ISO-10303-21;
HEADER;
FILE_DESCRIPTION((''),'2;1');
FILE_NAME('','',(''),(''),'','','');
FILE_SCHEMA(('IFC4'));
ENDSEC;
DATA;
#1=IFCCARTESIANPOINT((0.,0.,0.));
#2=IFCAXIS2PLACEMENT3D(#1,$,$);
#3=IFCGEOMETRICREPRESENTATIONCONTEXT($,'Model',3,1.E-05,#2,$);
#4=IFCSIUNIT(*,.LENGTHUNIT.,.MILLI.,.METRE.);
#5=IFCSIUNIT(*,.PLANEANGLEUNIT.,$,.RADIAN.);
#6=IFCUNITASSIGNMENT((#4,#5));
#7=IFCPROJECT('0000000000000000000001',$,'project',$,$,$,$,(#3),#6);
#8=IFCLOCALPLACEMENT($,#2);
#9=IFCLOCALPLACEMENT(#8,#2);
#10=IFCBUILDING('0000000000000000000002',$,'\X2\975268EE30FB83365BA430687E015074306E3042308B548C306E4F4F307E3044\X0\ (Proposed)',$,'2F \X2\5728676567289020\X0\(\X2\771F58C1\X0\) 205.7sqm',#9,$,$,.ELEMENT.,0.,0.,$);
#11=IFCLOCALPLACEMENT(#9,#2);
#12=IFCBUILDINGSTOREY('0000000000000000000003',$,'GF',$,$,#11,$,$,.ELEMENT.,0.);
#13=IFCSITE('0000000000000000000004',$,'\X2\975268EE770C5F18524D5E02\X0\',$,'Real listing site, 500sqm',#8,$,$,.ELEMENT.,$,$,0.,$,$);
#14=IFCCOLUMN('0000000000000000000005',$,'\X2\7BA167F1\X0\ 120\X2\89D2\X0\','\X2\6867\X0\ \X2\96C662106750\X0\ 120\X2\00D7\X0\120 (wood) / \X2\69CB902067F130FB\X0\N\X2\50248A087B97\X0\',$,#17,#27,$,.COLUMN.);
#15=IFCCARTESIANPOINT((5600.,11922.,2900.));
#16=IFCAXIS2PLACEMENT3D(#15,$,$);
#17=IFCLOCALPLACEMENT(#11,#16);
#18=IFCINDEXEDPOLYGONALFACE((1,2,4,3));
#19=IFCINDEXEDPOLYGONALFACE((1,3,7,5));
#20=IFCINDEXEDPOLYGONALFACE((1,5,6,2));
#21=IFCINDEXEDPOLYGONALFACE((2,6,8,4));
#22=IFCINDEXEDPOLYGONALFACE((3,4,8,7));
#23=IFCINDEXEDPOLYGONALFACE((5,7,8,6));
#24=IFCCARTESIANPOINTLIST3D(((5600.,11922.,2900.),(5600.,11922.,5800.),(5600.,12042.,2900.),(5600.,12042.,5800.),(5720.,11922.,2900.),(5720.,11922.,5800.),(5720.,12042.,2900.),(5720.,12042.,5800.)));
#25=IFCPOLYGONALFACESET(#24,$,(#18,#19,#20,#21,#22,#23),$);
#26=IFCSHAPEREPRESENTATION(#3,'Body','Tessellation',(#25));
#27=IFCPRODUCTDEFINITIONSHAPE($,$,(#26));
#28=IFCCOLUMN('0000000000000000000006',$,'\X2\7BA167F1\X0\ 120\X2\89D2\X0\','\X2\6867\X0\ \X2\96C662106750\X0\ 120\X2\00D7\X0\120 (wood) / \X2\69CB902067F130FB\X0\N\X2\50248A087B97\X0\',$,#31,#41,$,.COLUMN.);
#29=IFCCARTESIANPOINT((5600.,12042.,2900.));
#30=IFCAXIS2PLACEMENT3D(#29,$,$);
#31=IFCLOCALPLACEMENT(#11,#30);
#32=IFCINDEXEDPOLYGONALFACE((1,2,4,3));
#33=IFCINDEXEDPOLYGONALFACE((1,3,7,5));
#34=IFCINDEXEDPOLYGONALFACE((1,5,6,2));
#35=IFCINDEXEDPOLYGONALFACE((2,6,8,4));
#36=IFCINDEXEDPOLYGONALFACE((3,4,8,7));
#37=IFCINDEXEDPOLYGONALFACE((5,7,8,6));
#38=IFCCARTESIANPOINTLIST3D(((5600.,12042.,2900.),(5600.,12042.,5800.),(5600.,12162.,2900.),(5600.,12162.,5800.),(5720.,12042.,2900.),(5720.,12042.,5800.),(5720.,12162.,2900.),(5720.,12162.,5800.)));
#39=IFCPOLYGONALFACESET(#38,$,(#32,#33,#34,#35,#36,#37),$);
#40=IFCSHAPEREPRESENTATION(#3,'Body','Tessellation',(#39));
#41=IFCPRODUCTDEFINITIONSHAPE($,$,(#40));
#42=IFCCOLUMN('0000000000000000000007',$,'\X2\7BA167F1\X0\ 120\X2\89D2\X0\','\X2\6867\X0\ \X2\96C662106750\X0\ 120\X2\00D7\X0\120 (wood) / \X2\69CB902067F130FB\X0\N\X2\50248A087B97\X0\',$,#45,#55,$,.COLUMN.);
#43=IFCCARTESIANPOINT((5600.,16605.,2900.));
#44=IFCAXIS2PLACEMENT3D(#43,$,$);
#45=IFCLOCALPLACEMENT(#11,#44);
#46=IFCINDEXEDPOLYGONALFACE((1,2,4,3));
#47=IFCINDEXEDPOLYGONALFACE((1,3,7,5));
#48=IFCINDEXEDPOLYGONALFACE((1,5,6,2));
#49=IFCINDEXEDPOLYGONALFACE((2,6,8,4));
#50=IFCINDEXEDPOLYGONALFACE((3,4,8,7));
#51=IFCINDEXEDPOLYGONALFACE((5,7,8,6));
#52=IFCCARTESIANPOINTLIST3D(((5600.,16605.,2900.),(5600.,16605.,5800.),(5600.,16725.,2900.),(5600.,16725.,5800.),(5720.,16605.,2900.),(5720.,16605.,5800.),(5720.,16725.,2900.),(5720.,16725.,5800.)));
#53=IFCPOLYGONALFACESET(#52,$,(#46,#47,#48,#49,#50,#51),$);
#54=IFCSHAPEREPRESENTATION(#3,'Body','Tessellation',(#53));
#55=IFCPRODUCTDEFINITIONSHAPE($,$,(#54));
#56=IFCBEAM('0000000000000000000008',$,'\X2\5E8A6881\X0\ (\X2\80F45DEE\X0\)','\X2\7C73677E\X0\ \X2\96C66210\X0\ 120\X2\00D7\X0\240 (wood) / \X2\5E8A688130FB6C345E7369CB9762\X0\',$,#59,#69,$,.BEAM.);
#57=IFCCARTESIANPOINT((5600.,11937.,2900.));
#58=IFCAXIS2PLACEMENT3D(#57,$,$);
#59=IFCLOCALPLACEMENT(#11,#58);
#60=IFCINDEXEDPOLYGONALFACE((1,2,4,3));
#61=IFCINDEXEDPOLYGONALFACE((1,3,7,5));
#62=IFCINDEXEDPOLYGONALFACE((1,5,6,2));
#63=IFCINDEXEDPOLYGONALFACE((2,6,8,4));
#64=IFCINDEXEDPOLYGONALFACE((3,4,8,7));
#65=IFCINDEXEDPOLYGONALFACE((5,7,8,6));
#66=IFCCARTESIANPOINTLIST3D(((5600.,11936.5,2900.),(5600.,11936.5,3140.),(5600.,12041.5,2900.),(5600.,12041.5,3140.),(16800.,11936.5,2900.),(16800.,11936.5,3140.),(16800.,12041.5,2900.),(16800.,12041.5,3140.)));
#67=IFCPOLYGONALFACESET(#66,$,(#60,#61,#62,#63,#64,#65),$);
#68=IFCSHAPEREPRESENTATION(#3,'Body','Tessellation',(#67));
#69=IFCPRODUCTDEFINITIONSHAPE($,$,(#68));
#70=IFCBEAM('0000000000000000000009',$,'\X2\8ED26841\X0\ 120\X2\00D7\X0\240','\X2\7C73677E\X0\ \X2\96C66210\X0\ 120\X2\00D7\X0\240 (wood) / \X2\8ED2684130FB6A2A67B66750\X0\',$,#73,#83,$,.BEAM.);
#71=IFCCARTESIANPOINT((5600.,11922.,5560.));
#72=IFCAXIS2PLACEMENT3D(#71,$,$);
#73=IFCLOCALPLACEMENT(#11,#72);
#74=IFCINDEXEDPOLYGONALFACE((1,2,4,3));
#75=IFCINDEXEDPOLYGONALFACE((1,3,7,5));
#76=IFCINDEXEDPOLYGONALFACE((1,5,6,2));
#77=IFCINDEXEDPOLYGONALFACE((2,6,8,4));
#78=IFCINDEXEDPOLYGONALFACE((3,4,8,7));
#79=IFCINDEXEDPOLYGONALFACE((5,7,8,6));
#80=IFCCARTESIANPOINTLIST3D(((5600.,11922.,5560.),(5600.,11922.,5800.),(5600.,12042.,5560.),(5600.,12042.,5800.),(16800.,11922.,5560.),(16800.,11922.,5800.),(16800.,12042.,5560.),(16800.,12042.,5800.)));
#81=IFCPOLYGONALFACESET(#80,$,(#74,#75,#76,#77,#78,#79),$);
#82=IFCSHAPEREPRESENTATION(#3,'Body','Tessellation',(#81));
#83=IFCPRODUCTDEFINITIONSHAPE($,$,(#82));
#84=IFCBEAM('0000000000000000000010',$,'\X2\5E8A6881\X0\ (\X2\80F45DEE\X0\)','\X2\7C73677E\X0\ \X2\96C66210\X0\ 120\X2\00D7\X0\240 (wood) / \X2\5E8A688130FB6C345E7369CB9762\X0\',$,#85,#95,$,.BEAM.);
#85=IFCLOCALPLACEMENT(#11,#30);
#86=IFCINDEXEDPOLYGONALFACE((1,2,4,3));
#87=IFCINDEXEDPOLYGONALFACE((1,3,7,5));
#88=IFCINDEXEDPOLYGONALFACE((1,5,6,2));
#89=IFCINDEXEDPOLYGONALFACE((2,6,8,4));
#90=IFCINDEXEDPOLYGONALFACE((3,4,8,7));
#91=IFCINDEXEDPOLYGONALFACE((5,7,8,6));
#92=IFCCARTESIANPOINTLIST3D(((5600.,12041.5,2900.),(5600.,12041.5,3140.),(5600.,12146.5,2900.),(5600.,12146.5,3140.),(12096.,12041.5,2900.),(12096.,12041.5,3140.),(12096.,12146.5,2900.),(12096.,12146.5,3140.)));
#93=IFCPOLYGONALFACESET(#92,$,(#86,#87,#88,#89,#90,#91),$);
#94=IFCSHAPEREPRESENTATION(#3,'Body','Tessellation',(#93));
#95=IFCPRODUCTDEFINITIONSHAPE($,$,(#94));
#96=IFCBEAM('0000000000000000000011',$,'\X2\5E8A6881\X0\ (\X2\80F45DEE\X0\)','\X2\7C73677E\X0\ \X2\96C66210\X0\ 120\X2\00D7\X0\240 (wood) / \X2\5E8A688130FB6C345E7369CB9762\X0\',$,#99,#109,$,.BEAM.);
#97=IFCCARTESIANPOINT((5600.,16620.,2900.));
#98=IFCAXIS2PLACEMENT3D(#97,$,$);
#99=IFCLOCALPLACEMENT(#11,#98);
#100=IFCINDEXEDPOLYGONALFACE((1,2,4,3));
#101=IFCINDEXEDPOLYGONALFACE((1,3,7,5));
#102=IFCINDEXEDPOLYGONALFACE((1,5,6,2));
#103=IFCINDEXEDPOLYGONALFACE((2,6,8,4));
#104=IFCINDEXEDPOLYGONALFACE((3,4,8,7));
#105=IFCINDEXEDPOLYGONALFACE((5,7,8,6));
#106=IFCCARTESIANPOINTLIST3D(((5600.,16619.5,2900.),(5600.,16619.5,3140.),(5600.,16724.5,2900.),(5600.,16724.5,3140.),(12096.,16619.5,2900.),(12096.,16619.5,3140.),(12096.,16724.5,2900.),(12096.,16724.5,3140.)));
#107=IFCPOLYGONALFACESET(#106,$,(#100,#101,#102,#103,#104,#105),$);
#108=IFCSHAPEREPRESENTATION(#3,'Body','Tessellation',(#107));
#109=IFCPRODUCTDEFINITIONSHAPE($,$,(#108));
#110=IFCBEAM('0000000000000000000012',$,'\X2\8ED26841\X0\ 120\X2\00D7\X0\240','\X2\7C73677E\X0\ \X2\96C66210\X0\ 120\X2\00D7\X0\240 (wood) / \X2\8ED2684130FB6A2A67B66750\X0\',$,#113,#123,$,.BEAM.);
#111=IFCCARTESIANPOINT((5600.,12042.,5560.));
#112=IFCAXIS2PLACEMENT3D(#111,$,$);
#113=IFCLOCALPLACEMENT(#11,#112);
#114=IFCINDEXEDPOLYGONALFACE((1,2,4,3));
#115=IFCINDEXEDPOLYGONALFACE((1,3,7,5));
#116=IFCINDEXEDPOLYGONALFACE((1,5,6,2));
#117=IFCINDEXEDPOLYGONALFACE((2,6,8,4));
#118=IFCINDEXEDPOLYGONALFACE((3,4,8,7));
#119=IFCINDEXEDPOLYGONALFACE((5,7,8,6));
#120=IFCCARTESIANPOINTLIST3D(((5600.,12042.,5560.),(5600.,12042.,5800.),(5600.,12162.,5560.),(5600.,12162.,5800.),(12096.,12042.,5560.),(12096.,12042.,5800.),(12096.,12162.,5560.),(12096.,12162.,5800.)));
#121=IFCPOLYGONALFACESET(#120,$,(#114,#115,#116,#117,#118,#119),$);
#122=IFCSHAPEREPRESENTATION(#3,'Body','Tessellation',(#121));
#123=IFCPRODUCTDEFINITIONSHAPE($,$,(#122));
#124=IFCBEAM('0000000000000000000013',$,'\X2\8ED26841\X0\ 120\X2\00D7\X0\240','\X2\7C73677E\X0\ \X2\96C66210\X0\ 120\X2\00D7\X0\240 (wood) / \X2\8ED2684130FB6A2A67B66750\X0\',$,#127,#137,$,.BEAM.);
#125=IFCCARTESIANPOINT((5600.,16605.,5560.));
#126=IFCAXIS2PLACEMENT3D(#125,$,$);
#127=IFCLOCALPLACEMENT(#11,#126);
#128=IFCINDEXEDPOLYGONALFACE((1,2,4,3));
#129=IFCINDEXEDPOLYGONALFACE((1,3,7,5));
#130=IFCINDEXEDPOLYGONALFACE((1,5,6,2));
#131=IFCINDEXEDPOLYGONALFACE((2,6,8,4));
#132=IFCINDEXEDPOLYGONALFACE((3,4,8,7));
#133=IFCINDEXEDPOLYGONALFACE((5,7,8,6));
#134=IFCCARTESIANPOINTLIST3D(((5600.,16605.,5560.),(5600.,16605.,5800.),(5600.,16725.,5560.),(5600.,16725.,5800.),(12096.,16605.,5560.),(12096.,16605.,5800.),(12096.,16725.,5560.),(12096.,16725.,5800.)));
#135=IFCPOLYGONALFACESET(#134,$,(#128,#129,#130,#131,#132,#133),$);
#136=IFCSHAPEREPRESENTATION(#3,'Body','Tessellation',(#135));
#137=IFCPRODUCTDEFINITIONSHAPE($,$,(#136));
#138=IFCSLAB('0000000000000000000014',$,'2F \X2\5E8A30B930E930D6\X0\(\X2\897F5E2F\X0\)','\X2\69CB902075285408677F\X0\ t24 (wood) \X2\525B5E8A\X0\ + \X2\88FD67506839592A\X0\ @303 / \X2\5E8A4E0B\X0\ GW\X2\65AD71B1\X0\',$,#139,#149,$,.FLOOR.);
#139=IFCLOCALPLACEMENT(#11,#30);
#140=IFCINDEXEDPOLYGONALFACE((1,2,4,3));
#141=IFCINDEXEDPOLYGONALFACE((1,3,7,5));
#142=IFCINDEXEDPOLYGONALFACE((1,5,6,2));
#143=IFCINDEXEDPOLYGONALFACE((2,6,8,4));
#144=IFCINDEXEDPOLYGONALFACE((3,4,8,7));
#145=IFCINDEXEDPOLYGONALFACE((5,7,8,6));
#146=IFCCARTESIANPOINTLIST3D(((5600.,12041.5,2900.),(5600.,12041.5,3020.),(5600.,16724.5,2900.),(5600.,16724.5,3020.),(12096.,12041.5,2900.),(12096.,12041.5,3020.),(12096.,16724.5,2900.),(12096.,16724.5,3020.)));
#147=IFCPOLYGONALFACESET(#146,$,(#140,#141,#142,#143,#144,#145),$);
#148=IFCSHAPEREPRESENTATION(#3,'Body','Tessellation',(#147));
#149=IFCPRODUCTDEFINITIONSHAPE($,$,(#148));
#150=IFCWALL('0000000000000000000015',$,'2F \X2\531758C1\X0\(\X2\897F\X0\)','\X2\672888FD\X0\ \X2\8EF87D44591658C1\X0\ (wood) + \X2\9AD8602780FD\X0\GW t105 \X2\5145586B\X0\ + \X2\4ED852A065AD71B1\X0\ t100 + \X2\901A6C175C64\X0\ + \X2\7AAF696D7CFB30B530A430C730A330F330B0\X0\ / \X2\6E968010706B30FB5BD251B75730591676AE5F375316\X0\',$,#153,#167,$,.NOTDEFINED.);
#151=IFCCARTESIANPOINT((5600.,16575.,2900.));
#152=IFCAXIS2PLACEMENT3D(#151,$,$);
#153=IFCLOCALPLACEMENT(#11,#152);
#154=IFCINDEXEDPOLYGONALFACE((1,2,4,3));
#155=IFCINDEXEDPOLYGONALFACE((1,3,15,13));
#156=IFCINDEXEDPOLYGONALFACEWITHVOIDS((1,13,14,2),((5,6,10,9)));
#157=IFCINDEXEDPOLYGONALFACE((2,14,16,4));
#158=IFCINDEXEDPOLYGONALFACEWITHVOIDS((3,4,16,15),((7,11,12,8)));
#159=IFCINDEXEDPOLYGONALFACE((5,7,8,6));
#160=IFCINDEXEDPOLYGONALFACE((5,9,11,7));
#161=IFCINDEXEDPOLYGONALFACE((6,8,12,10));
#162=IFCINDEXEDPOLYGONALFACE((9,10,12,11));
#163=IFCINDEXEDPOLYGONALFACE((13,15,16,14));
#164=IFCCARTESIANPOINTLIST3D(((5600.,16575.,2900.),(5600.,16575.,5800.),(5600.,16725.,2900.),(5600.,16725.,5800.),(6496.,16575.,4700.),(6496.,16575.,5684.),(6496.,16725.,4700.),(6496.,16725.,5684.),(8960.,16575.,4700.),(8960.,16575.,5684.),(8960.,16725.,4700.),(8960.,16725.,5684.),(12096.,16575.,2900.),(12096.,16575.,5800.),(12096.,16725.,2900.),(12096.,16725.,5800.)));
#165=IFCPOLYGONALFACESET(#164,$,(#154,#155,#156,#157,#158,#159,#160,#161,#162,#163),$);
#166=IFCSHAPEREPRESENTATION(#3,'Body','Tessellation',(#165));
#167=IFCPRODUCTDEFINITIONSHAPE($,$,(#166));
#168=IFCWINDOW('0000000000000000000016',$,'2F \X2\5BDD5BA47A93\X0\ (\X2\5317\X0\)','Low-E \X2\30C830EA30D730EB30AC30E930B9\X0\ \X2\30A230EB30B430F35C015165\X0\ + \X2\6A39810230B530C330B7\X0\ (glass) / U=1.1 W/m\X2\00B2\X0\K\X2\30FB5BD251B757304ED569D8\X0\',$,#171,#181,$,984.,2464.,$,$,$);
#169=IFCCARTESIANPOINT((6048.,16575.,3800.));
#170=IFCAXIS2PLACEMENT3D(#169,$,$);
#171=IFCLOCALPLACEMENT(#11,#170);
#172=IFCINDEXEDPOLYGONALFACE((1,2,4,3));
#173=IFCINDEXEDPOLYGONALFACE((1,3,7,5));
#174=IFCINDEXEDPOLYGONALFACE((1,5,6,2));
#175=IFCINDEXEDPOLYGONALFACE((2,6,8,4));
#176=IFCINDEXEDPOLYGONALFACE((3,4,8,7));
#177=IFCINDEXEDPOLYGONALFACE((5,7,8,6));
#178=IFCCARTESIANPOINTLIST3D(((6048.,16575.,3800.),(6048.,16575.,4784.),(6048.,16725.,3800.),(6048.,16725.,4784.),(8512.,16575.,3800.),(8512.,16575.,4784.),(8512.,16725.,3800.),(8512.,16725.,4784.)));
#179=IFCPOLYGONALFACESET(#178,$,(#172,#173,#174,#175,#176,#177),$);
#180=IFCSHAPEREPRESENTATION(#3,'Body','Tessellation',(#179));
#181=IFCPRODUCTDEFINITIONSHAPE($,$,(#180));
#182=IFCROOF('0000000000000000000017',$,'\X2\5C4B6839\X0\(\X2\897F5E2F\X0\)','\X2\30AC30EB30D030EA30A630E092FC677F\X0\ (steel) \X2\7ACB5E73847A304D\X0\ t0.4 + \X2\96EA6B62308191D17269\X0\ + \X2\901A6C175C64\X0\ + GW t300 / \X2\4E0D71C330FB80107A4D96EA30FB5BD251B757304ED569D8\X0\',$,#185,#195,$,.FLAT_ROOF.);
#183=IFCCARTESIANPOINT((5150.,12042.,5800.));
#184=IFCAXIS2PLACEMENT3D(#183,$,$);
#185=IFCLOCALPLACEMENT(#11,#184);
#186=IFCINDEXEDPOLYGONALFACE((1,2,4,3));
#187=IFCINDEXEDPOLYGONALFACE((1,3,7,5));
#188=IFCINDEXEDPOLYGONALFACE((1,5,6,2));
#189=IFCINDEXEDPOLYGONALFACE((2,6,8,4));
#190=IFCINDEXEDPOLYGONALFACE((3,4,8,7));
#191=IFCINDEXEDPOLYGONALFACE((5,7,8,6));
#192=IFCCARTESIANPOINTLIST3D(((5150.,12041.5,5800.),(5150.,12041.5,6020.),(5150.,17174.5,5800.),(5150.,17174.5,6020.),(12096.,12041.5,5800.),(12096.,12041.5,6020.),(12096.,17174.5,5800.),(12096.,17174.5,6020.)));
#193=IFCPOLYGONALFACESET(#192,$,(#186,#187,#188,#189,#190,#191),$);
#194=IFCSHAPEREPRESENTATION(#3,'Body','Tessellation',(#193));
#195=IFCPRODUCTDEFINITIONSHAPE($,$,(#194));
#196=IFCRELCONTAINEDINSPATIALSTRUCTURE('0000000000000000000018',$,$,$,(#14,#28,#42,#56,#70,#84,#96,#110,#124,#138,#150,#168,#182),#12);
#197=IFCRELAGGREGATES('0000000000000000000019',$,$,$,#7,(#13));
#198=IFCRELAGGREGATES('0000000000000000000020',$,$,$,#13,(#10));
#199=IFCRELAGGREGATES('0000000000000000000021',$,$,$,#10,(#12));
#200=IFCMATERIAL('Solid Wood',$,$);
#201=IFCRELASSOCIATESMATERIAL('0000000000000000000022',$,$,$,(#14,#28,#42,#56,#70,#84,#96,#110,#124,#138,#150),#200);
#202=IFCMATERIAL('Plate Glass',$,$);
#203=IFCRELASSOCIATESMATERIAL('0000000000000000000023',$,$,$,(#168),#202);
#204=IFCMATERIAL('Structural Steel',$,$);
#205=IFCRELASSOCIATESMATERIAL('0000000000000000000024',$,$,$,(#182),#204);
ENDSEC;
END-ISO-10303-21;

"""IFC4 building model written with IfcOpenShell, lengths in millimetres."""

from ifc_helpers import new_model, si_unit, frame, frame_2d, origin, place, context, project, spatial, rectangle, extrude, material, element, fill, save


model = new_model("IFC4")

# Units and contexts
model_context = context("Model", 3, precision=1e-05, world=origin())
ifc_project = project(units=[si_unit("LENGTHUNIT", "METRE", prefix="MILLI"), si_unit("PLANEANGLEUNIT", "RADIAN")], contexts=[model_context])

# Site, building, storey
site_placement = place(None, origin())
site = spatial("IfcSite", under=ifc_project, at=site_placement, Name="青森県弘前市", ObjectType="Real listing site, 500sqm", CompositionType="ELEMENT", RefElevation=0.0)
building_placement = place(site_placement, origin())
building = spatial("IfcBuilding", under=site, at=building_placement, Name="青森・茶室と縁側のある和の住まい (Proposed)", ObjectType="2F 在来木造(真壁) 205.7sqm", CompositionType="ELEMENT", ElevationOfRefHeight=0.0, ElevationOfTerrain=0.0)
storey_placement = place(building_placement, origin())
storey = spatial("IfcBuildingStorey", under=building, at=storey_placement, Name="GF", CompositionType="ELEMENT", Elevation=0.0)

# Columns
ifc_material_1 = material(Name="Solid Wood")
column_1_placement = place(storey_placement, frame((5600.0, 11922.0, 2900.0)))
element("IfcColumn", 1, at=column_1_placement, inside=storey, material=ifc_material_1, Name="管柱 120角", Description="桧 集成材 120×120 (wood) / 構造柱・N値計算", PredefinedType="COLUMN", context=model_context, shape_type="SweptSolid", body=[
    extrude(rectangle(XDim=120.0, YDim=120.0, at=frame_2d((60.0, 60.0))), frame((5600.0, 11922.0, 2900.0)), (0.0, 0.0, 1.0), 2900.0),
])
column_2_placement = place(storey_placement, frame((5600.0, 12042.0, 2900.0)))
element("IfcColumn", 2, at=column_2_placement, inside=storey, material=ifc_material_1, Name="管柱 120角", Description="桧 集成材 120×120 (wood) / 構造柱・N値計算", PredefinedType="COLUMN", context=model_context, shape_type="SweptSolid", body=[
    extrude(rectangle(XDim=120.0, YDim=120.0, at=frame_2d((60.0, 60.0))), frame((5600.0, 12042.0, 2900.0)), (0.0, 0.0, 1.0), 2900.0),
])
column_3_placement = place(storey_placement, frame((5600.0, 16605.0, 2900.0)))
element("IfcColumn", 3, at=column_3_placement, inside=storey, material=ifc_material_1, Name="管柱 120角", Description="桧 集成材 120×120 (wood) / 構造柱・N値計算", PredefinedType="COLUMN", context=model_context, shape_type="SweptSolid", body=[
    extrude(rectangle(XDim=120.0, YDim=120.0, at=frame_2d((60.0, 60.0))), frame((5600.0, 16605.0, 2900.0)), (0.0, 0.0, 1.0), 2900.0),
])

# Beams
beam_1_placement = place(storey_placement, frame((5600.0, 11937.0, 2900.0)))
element("IfcBeam", 4, at=beam_1_placement, inside=storey, material=ifc_material_1, Name="床梁 (胴差)", Description="米松 集成 120×240 (wood) / 床梁・水平構面", PredefinedType="BEAM", context=model_context, shape_type="SweptSolid", body=[
    extrude(rectangle(XDim=11200.0, YDim=105.0, at=frame_2d((5600.0, 52.0))), frame((5600.0, 11937.0, 2900.0)), (0.0, 0.0, 1.0), 240.0),
])
beam_2_placement = place(storey_placement, frame((5600.0, 11922.0, 5560.0)))
element("IfcBeam", 5, at=beam_2_placement, inside=storey, material=ifc_material_1, Name="軒桁 120×240", Description="米松 集成 120×240 (wood) / 軒桁・横架材", PredefinedType="BEAM", context=model_context, shape_type="SweptSolid", body=[
    extrude(rectangle(XDim=11200.0, YDim=120.0, at=frame_2d((5600.0, 60.0))), frame((5600.0, 11922.0, 5560.0)), (0.0, 0.0, 1.0), 240.0),
])
beam_3_placement = place(storey_placement, frame((5600.0, 12042.0, 2900.0)))
element("IfcBeam", 6, at=beam_3_placement, inside=storey, material=ifc_material_1, Name="床梁 (胴差)", Description="米松 集成 120×240 (wood) / 床梁・水平構面", PredefinedType="BEAM", context=model_context, shape_type="SweptSolid", body=[
    extrude(rectangle(XDim=6496.0, YDim=105.0, at=frame_2d((3248.0, 52.0))), frame((5600.0, 12042.0, 2900.0)), (0.0, 0.0, 1.0), 240.0),
])
beam_4_placement = place(storey_placement, frame((5600.0, 16620.0, 2900.0)))
element("IfcBeam", 7, at=beam_4_placement, inside=storey, material=ifc_material_1, Name="床梁 (胴差)", Description="米松 集成 120×240 (wood) / 床梁・水平構面", PredefinedType="BEAM", context=model_context, shape_type="SweptSolid", body=[
    extrude(rectangle(XDim=6496.0, YDim=105.0, at=frame_2d((3248.0, 52.0))), frame((5600.0, 16620.0, 2900.0)), (0.0, 0.0, 1.0), 240.0),
])
beam_5_placement = place(storey_placement, frame((5600.0, 12042.0, 5560.0)))
element("IfcBeam", 8, at=beam_5_placement, inside=storey, material=ifc_material_1, Name="軒桁 120×240", Description="米松 集成 120×240 (wood) / 軒桁・横架材", PredefinedType="BEAM", context=model_context, shape_type="SweptSolid", body=[
    extrude(rectangle(XDim=6496.0, YDim=120.0, at=frame_2d((3248.0, 60.0))), frame((5600.0, 12042.0, 5560.0)), (0.0, 0.0, 1.0), 240.0),
])
beam_6_placement = place(storey_placement, frame((5600.0, 16605.0, 5560.0)))
element("IfcBeam", 9, at=beam_6_placement, inside=storey, material=ifc_material_1, Name="軒桁 120×240", Description="米松 集成 120×240 (wood) / 軒桁・横架材", PredefinedType="BEAM", context=model_context, shape_type="SweptSolid", body=[
    extrude(rectangle(XDim=6496.0, YDim=120.0, at=frame_2d((3248.0, 60.0))), frame((5600.0, 16605.0, 5560.0)), (0.0, 0.0, 1.0), 240.0),
])

# Slab
slab_placement = place(storey_placement, frame((5600.0, 12042.0, 2900.0)))
element("IfcSlab", 10, at=slab_placement, inside=storey, material=ifc_material_1, Name="2F 床スラブ(西帯)", Description="構造用合板 t24 (wood) 剛床 + 製材根太 @303 / 床下 GW断熱", PredefinedType="FLOOR", context=model_context, shape_type="SweptSolid", body=[
    extrude(rectangle(XDim=6496.0, YDim=4683.0, at=frame_2d((3248.0, 2341.0))), frame((5600.0, 12042.0, 2900.0)), (0.0, 0.0, 1.0), 120.0),
])

# Wall, opening, window
wall_1_placement = place(storey_placement, frame((5600.0, 16575.0, 2900.0)))
wall_1 = element("IfcWall", 11, at=wall_1_placement, inside=storey, material=ifc_material_1, Name="2F 北壁(西)", Description="木製 軸組外壁 (wood) + 高性能GW t105 充填 + 付加断熱 t100 + 通気層 + 窯業系サイディング / 準耐火・寒冷地外皮強化", PredefinedType="NOTDEFINED", context=model_context, shape_type="SweptSolid", body=[
    extrude(rectangle(XDim=6496.0, YDim=150.0, at=frame_2d((3248.0, 75.0))), frame((5600.0, 16575.0, 2900.0)), (0.0, 0.0, 1.0), 2900.0),
])
opening_placement = place(storey_placement, frame((6048.0, 16575.0, 3800.0)))
opening = element("IfcOpeningElement", 12, at=opening_placement, cuts=wall_1, PredefinedType="NOTDEFINED", context=model_context, shape_type="SweptSolid", body=[
    extrude(rectangle(XDim=2464.0, YDim=150.0, at=frame_2d((1232.0, 75.0))), frame((6048.0, 16575.0, 3800.0)), (0.0, 0.0, 1.0), 984.0),
])
ifc_material_2 = material(Name="Plate Glass")
window_placement = place(storey_placement, frame((6048.0, 16575.0, 3800.0)))
window = element("IfcWindow", 13, at=window_placement, inside=storey, material=ifc_material_2, Name="2F 寝室窓 (北)", Description="Low-E トリプルガラス アルゴン封入 + 樹脂サッシ (glass) / U=1.1 W/m²K・寒冷地仕様", OverallHeight=984.0, OverallWidth=2464.0, context=model_context, shape_type="SweptSolid", body=[
    extrude(rectangle(XDim=2464.0, YDim=150.0, at=frame_2d((1232.0, 75.0))), frame((6048.0, 16575.0, 3800.0)), (0.0, 0.0, 1.0), 984.0),
])
fill(opening, window)

# Roof
ifc_material_3 = material(Name="Structural Steel")
for number, where, name in (
    (14, (5150.0, 12042.0, 5800.0), "屋根(西帯)"),
):
    element("IfcRoof", number, at=place(storey_placement, frame(where)), inside=storey, material=ifc_material_3, Name=name, Description="ガルバリウム鋼板 (steel) 立平葺き t0.4 + 雪止め金物 + 通気層 + GW t300 / 不燃・耐積雪・寒冷地仕様", PredefinedType="FLAT_ROOF", context=model_context, shape_type="SweptSolid", body=[
        extrude(rectangle(XDim=6946.0, YDim=5133.0, at=frame_2d((3473.0, 2566.0))), frame((5150.0, 12042.0, 5800.0)), (0.0, 0.0, 1.0), 220.0),
    ])

save(model, "model.ifc")
